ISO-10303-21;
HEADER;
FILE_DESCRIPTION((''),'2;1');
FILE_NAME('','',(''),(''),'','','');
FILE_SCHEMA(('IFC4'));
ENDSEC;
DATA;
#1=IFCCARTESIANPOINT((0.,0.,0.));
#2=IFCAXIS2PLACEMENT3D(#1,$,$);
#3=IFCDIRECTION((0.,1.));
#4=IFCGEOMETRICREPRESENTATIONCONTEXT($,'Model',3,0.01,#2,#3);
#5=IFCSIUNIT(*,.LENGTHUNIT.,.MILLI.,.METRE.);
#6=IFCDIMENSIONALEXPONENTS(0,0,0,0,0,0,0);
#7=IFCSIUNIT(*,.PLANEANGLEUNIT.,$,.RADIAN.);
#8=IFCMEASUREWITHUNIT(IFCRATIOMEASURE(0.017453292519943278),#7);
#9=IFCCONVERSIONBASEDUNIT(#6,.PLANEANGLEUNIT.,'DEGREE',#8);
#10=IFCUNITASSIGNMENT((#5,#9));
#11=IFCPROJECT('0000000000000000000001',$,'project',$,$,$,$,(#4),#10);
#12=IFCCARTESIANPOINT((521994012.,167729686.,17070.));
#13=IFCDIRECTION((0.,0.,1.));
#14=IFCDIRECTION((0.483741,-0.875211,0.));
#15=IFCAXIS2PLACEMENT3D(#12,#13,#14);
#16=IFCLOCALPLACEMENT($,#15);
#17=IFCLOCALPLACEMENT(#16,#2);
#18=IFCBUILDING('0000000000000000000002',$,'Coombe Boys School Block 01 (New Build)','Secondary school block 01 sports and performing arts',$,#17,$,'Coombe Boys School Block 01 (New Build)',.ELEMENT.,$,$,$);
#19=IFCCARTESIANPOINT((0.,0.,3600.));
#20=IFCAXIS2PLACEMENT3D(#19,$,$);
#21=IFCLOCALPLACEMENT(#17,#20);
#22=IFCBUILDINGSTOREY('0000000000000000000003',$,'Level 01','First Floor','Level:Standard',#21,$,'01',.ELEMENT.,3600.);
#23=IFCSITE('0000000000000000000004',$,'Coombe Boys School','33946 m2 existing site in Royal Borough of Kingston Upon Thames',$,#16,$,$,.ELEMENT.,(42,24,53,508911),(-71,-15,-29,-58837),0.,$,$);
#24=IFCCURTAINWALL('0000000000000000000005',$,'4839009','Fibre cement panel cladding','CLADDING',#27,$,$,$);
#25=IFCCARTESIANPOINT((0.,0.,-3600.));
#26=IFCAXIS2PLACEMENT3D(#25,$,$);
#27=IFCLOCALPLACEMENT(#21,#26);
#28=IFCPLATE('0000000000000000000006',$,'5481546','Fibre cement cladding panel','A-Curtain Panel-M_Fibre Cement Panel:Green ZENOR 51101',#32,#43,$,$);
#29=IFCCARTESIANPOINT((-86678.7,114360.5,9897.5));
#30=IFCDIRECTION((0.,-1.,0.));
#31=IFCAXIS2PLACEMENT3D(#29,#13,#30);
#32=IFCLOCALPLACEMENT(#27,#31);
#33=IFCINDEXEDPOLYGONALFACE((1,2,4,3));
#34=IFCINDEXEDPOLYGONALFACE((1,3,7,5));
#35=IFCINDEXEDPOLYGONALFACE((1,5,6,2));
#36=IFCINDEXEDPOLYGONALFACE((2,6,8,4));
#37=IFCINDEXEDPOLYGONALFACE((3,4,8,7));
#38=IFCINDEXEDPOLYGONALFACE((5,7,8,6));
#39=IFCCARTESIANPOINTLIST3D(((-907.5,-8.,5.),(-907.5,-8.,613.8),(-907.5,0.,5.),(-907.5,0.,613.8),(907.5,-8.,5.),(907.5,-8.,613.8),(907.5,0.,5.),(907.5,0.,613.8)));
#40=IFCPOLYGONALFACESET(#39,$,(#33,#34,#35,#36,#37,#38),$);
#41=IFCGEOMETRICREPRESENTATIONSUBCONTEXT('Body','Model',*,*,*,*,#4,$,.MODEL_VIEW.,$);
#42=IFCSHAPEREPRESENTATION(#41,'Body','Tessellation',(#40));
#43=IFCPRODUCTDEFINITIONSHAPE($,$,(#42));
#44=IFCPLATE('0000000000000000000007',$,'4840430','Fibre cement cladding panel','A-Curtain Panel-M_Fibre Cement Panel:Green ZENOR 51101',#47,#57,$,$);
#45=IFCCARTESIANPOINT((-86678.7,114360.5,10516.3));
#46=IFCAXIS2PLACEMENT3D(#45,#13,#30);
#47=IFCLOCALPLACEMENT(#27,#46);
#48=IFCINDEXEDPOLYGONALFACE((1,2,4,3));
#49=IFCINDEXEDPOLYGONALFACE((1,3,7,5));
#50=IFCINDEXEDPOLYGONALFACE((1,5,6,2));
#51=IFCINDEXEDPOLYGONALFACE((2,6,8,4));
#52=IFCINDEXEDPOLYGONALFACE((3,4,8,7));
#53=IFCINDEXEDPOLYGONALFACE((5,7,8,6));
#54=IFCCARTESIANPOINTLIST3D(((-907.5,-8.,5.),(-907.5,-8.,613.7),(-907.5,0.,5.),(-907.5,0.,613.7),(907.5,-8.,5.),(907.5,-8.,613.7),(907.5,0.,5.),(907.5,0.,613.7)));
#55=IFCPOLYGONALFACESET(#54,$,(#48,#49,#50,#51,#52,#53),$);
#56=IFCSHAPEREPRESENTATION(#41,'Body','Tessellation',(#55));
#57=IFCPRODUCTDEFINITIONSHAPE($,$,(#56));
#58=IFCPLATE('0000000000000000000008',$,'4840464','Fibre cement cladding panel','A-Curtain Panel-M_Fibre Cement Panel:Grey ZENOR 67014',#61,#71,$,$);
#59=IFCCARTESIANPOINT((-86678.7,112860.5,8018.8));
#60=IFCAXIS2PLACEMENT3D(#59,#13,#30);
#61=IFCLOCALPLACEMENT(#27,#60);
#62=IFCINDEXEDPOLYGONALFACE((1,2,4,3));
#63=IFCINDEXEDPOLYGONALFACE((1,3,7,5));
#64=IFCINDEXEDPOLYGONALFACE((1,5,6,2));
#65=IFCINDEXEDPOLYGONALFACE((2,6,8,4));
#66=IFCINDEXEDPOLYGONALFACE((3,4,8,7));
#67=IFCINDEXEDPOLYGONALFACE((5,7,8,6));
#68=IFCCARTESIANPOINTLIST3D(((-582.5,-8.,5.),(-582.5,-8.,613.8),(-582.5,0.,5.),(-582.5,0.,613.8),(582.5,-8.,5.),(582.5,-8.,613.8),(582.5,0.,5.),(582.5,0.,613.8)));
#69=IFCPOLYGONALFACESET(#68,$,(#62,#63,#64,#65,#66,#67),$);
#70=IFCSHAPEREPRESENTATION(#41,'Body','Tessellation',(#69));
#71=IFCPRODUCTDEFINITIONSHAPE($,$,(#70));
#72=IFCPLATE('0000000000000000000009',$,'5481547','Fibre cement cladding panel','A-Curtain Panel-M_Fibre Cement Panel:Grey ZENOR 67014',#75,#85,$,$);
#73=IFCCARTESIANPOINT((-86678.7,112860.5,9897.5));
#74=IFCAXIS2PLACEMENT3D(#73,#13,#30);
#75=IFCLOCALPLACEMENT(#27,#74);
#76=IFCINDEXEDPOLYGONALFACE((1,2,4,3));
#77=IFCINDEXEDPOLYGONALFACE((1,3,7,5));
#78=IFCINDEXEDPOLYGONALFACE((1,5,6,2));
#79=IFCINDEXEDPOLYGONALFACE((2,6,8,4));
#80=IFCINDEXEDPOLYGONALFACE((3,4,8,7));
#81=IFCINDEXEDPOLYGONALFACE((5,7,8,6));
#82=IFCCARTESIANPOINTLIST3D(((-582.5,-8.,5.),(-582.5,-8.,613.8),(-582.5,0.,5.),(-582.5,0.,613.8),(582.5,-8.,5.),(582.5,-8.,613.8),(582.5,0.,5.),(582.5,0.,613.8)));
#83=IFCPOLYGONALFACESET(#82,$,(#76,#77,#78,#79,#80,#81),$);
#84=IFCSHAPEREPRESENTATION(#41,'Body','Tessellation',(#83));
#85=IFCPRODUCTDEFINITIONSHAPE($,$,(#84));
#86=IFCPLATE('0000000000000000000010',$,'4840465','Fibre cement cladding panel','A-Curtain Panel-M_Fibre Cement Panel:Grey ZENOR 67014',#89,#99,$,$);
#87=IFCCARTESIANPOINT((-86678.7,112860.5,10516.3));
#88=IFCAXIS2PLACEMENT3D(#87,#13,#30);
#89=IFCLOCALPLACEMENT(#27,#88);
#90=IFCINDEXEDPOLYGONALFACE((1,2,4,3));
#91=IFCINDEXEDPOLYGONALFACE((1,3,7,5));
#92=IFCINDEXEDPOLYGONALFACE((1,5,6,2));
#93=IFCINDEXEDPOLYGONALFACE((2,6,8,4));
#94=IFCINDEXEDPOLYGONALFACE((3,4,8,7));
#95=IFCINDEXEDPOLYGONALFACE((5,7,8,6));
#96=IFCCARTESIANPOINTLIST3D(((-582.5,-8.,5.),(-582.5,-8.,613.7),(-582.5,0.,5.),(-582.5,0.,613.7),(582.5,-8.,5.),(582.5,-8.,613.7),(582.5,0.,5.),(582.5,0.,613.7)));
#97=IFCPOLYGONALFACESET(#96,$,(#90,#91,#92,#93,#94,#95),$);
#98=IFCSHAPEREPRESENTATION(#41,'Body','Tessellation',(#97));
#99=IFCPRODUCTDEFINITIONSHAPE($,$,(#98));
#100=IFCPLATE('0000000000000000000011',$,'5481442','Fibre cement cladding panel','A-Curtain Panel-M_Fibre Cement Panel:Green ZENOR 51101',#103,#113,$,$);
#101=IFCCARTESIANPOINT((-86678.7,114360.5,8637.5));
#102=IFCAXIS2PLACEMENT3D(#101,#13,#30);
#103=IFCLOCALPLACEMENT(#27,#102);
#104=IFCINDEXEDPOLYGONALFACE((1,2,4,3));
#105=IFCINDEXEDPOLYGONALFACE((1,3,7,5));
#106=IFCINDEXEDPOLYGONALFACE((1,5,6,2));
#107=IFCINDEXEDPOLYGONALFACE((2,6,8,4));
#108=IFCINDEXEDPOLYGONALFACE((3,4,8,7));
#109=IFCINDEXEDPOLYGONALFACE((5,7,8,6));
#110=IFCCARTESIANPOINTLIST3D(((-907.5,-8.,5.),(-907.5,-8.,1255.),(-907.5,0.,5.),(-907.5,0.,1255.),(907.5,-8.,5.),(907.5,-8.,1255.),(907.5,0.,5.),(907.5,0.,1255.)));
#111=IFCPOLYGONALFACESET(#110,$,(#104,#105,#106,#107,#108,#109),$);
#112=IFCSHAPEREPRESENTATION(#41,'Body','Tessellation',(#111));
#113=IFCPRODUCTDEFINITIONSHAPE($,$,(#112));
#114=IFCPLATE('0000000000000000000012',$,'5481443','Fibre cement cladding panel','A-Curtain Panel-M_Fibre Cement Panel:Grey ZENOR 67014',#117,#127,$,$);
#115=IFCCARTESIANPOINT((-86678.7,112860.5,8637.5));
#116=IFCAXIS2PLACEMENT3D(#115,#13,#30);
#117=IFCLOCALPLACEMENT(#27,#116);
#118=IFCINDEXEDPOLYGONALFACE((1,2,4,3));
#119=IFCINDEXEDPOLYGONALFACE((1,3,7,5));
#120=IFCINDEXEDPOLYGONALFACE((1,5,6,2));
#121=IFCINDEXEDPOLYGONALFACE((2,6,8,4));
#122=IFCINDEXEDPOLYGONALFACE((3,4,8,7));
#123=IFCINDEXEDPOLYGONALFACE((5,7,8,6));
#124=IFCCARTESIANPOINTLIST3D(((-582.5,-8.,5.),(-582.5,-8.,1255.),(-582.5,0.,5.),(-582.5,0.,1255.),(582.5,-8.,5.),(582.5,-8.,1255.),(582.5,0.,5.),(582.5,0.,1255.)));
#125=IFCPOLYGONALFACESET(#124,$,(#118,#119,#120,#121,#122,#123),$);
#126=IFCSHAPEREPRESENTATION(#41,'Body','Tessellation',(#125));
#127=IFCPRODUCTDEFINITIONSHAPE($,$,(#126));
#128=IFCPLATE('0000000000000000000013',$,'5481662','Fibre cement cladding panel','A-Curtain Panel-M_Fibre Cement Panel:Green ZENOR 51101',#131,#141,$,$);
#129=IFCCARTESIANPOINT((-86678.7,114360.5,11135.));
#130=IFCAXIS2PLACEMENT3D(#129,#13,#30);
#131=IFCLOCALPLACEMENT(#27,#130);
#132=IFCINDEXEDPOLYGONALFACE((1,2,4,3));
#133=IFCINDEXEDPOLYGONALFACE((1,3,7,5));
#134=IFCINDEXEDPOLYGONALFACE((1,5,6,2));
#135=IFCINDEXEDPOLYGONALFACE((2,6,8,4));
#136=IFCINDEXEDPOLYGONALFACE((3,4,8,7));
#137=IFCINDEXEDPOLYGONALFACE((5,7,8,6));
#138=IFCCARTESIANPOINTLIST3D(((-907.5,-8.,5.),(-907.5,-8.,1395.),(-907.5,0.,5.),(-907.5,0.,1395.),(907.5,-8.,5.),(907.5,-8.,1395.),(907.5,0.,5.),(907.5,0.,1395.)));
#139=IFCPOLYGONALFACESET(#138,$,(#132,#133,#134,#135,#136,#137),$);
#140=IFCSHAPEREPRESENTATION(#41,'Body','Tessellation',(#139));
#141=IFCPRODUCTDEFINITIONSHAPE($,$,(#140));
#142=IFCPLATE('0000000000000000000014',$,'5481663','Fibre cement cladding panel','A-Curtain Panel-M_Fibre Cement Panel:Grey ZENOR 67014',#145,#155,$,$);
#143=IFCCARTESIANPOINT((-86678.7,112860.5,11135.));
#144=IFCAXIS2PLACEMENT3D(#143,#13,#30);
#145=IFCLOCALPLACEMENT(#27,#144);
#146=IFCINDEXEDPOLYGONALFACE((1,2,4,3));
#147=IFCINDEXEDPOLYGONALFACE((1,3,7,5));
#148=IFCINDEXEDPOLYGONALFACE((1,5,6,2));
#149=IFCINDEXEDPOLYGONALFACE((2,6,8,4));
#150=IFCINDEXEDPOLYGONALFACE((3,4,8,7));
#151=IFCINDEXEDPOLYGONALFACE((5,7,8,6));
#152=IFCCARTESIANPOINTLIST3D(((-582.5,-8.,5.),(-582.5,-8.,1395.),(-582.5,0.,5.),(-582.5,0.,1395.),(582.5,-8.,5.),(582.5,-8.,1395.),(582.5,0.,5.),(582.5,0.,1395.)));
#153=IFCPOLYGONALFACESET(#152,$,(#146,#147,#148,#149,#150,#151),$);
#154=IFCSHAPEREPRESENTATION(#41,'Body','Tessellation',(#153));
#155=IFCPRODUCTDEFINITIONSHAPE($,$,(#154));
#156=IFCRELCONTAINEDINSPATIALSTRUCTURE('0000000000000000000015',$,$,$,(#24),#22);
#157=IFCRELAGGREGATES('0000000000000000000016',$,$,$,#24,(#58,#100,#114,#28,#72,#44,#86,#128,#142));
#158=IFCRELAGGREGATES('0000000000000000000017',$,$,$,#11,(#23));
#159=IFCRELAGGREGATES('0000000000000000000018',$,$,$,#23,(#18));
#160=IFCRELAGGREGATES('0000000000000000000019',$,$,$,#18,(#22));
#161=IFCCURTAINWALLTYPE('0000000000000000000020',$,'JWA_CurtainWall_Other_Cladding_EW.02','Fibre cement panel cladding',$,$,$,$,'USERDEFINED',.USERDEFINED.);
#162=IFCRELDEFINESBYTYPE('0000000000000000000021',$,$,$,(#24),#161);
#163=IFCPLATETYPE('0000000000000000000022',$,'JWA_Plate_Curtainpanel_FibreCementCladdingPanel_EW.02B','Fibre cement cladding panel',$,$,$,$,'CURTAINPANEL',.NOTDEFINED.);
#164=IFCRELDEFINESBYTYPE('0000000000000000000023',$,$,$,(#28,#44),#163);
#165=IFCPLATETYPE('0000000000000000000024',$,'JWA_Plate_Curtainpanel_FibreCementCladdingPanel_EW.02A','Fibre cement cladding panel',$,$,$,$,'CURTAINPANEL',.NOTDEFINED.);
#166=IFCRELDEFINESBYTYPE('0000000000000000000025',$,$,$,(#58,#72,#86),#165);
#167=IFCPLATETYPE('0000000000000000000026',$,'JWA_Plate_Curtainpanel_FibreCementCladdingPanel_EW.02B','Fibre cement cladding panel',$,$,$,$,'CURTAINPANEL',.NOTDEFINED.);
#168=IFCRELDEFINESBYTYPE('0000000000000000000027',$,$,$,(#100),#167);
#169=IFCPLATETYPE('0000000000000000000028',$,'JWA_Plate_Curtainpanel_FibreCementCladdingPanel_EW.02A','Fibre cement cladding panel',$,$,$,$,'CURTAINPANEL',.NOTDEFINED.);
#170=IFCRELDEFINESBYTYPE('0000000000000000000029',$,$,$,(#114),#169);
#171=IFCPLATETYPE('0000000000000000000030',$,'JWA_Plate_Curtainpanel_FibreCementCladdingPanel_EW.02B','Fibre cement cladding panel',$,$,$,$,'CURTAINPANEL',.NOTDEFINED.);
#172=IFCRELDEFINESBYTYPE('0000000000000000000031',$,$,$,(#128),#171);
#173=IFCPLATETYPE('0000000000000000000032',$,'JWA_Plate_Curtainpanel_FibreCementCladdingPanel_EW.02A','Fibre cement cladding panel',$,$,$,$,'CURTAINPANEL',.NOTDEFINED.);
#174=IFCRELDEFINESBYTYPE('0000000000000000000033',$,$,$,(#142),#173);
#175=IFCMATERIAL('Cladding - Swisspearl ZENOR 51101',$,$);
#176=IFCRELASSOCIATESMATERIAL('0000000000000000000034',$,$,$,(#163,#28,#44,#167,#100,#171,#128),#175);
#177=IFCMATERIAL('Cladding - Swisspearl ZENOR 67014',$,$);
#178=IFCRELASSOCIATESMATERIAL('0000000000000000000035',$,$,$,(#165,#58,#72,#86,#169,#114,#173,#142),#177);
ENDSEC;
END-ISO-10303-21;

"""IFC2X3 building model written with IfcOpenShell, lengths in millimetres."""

from ifc_helpers import new_model, entity, si_unit, converted_unit, direction, frame, origin, origin_2d_with_axis, place, context, subcontext, project, spatial, rectangle, extrude, source, transform, mapped, material, type_object, type_shapes, element, aggregate, save


model = new_model("IFC2X3")

# Units and contexts
model_context = context("Model", 3, precision=0.01, world=origin(), true_north=direction((0.0, 1.0)))
body_context = subcontext(model_context, "Body", "Model", "MODEL_VIEW")
ifc_project = project(units=[si_unit("LENGTHUNIT", "METRE", prefix="MILLI"), converted_unit("PLANEANGLEUNIT", "DEGREE", entity("IfcRatioMeasure", 0.017453292519943278), si_unit("PLANEANGLEUNIT", "RADIAN"), dimensions=[0, 0, 0, 0, 0, 0, 0])], contexts=[model_context])

# Site, building, storey
site_placement = place(None, frame((521994012.0, 167729686.0, 17070.0), z_axis=(0.0, 0.0, 1.0), x_axis=(0.483741, -0.875211, 0.0)))
site = spatial("IfcSite", under=ifc_project, at=site_placement, Name="Coombe Boys School", Description="33946 m2 existing site in Royal Borough of Kingston Upon Thames", CompositionType="ELEMENT", RefLatitude=(42, 24, 53, 508911), RefLongitude=(-71, -15, -29, -58837), RefElevation=0.0)
building_placement = place(site_placement, origin())
building = spatial("IfcBuilding", under=site, at=building_placement, Name="Coombe Boys School Block 01 (New Build)", Description="Secondary school block 01 sports and performing arts", LongName="Coombe Boys School Block 01 (New Build)", CompositionType="ELEMENT")
storey_placement = place(building_placement, frame((0.0, 0.0, 3600.0)))
storey = spatial("IfcBuildingStorey", under=building, at=storey_placement, Name="Level 01", Description="First Floor", ObjectType="Level:Standard", LongName="01", CompositionType="ELEMENT", Elevation=3600.0)

# Curtain wall, plates
curtain_wall_type = type_object("IfcCurtainWallType", Name="JWA_CurtainWall_Other_Cladding_EW.02", Description="Fibre cement panel cladding", ElementType="USERDEFINED", PredefinedType="USERDEFINED")
curtain_wall_placement = place(storey_placement, frame((0.0, 0.0, -3600.0)))
curtain_wall = element("IfcCurtainWall", 1, at=curtain_wall_placement, inside=storey, type_object=curtain_wall_type, Name="4839009", Description="Fibre cement panel cladding", ObjectType="CLADDING")
ifc_material_1 = material(Name="Cladding - Swisspearl ZENOR 51101")
plate_type_1 = type_object("IfcPlateType", Name="JWA_Plate_Curtainpanel_FibreCementCladdingPanel_EW.02B", Description="Fibre cement cladding panel", ElementType="CURTAINPANEL", PredefinedType="NOTDEFINED", material=ifc_material_1)
shared_shape_1 = source(origin(), body_context, "Body", "SweptSolid", [
    extrude(rectangle(XDim=1815.0, YDim=8.0, at=origin_2d_with_axis()), frame((0.0, -4.0, 5.0), z_axis=(0.0, 0.0, 1.0), x_axis=(-1.0, 0.0, 0.0)), (0.0, 0.0, 1.0), 608.8),
])
type_shapes(plate_type_1, [shared_shape_1])
plate_1_placement = place(curtain_wall_placement, frame((-86678.7, 114360.5, 9897.5), z_axis=(0.0, 0.0, 1.0), x_axis=(0.0, -1.0, 0.0)))
plate_1 = element("IfcPlate", 2, at=plate_1_placement, type_object=plate_type_1, material=ifc_material_1, Name="5481546", Description="Fibre cement cladding panel", ObjectType="A-Curtain Panel-M_Fibre Cement Panel:Green ZENOR 51101", context=body_context, shape_type="MappedRepresentation", body=[
    mapped(shared_shape_1, transform((0.0, 0.0, 0.0), scale=1.0)),
])
plate_2_placement = place(curtain_wall_placement, frame((-86678.7, 114360.5, 10516.3), z_axis=(0.0, 0.0, 1.0), x_axis=(0.0, -1.0, 0.0)))
plate_2 = element("IfcPlate", 3, at=plate_2_placement, type_object=plate_type_1, material=ifc_material_1, Name="4840430", Description="Fibre cement cladding panel", ObjectType="A-Curtain Panel-M_Fibre Cement Panel:Green ZENOR 51101", context=body_context, shape_type="MappedRepresentation", body=[
    mapped(shared_shape_1, transform((0.0, 0.0, 0.0), scale=1.0)),
])
ifc_material_2 = material(Name="Cladding - Swisspearl ZENOR 67014")
plate_type_2 = type_object("IfcPlateType", Name="JWA_Plate_Curtainpanel_FibreCementCladdingPanel_EW.02A", Description="Fibre cement cladding panel", ElementType="CURTAINPANEL", PredefinedType="NOTDEFINED", material=ifc_material_2)
shared_shape_2 = source(origin(), body_context, "Body", "SweptSolid", [
    extrude(rectangle(XDim=1165.0, YDim=8.0, at=origin_2d_with_axis()), frame((0.0, -4.0, 5.0), z_axis=(0.0, 0.0, 1.0), x_axis=(-1.0, 0.0, 0.0)), (0.0, 0.0, 1.0), 608.8),
])
type_shapes(plate_type_2, [shared_shape_2])
plate_3_placement = place(curtain_wall_placement, frame((-86678.7, 112860.5, 8018.8), z_axis=(0.0, 0.0, 1.0), x_axis=(0.0, -1.0, 0.0)))
plate_3 = element("IfcPlate", 4, at=plate_3_placement, type_object=plate_type_2, material=ifc_material_2, Name="4840464", Description="Fibre cement cladding panel", ObjectType="A-Curtain Panel-M_Fibre Cement Panel:Grey ZENOR 67014", context=body_context, shape_type="MappedRepresentation", body=[
    mapped(shared_shape_2, transform((0.0, 0.0, 0.0), scale=1.0)),
])
plate_4_placement = place(curtain_wall_placement, frame((-86678.7, 112860.5, 9897.5), z_axis=(0.0, 0.0, 1.0), x_axis=(0.0, -1.0, 0.0)))
plate_4 = element("IfcPlate", 5, at=plate_4_placement, type_object=plate_type_2, material=ifc_material_2, Name="5481547", Description="Fibre cement cladding panel", ObjectType="A-Curtain Panel-M_Fibre Cement Panel:Grey ZENOR 67014", context=body_context, shape_type="MappedRepresentation", body=[
    mapped(shared_shape_2, transform((0.0, 0.0, 0.0), scale=1.0)),
])
plate_5_placement = place(curtain_wall_placement, frame((-86678.7, 112860.5, 10516.3), z_axis=(0.0, 0.0, 1.0), x_axis=(0.0, -1.0, 0.0)))
plate_5 = element("IfcPlate", 6, at=plate_5_placement, type_object=plate_type_2, material=ifc_material_2, Name="4840465", Description="Fibre cement cladding panel", ObjectType="A-Curtain Panel-M_Fibre Cement Panel:Grey ZENOR 67014", context=body_context, shape_type="MappedRepresentation", body=[
    mapped(shared_shape_2, transform((0.0, 0.0, 0.0), scale=1.0)),
])
plate_type_3 = type_object("IfcPlateType", Name="JWA_Plate_Curtainpanel_FibreCementCladdingPanel_EW.02B", Description="Fibre cement cladding panel", ElementType="CURTAINPANEL", PredefinedType="NOTDEFINED", material=ifc_material_1)
shared_shape_3 = source(origin(), body_context, "Body", "SweptSolid", [
    extrude(rectangle(XDim=1815.0, YDim=8.0, at=origin_2d_with_axis()), frame((0.0, -4.0, 5.0), z_axis=(0.0, 0.0, 1.0), x_axis=(-1.0, 0.0, 0.0)), (0.0, 0.0, 1.0), 1250.0),
])
type_shapes(plate_type_3, [shared_shape_3])
plate_6_placement = place(curtain_wall_placement, frame((-86678.7, 114360.5, 8637.5), z_axis=(0.0, 0.0, 1.0), x_axis=(0.0, -1.0, 0.0)))
plate_6 = element("IfcPlate", 7, at=plate_6_placement, type_object=plate_type_3, material=ifc_material_1, Name="5481442", Description="Fibre cement cladding panel", ObjectType="A-Curtain Panel-M_Fibre Cement Panel:Green ZENOR 51101", context=body_context, shape_type="MappedRepresentation", body=[
    mapped(shared_shape_3, transform((0.0, 0.0, 0.0), scale=1.0)),
])
plate_type_4 = type_object("IfcPlateType", Name="JWA_Plate_Curtainpanel_FibreCementCladdingPanel_EW.02A", Description="Fibre cement cladding panel", ElementType="CURTAINPANEL", PredefinedType="NOTDEFINED", material=ifc_material_2)
shared_shape_4 = source(origin(), body_context, "Body", "SweptSolid", [
    extrude(rectangle(XDim=1165.0, YDim=8.0, at=origin_2d_with_axis()), frame((0.0, -4.0, 5.0), z_axis=(0.0, 0.0, 1.0), x_axis=(-1.0, 0.0, 0.0)), (0.0, 0.0, 1.0), 1250.0),
])
type_shapes(plate_type_4, [shared_shape_4])
plate_7_placement = place(curtain_wall_placement, frame((-86678.7, 112860.5, 8637.5), z_axis=(0.0, 0.0, 1.0), x_axis=(0.0, -1.0, 0.0)))
plate_7 = element("IfcPlate", 8, at=plate_7_placement, type_object=plate_type_4, material=ifc_material_2, Name="5481443", Description="Fibre cement cladding panel", ObjectType="A-Curtain Panel-M_Fibre Cement Panel:Grey ZENOR 67014", context=body_context, shape_type="MappedRepresentation", body=[
    mapped(shared_shape_4, transform((0.0, 0.0, 0.0), scale=1.0)),
])
plate_type_5 = type_object("IfcPlateType", Name="JWA_Plate_Curtainpanel_FibreCementCladdingPanel_EW.02B", Description="Fibre cement cladding panel", ElementType="CURTAINPANEL", PredefinedType="NOTDEFINED", material=ifc_material_1)
shared_shape_5 = source(origin(), body_context, "Body", "SweptSolid", [
    extrude(rectangle(XDim=1815.0, YDim=8.0, at=origin_2d_with_axis()), frame((0.0, -4.0, 5.0), z_axis=(0.0, 0.0, 1.0), x_axis=(-1.0, 0.0, 0.0)), (0.0, 0.0, 1.0), 1390.0),
])
type_shapes(plate_type_5, [shared_shape_5])
plate_8_placement = place(curtain_wall_placement, frame((-86678.7, 114360.5, 11135.0), z_axis=(0.0, 0.0, 1.0), x_axis=(0.0, -1.0, 0.0)))
plate_8 = element("IfcPlate", 9, at=plate_8_placement, type_object=plate_type_5, material=ifc_material_1, Name="5481662", Description="Fibre cement cladding panel", ObjectType="A-Curtain Panel-M_Fibre Cement Panel:Green ZENOR 51101", context=body_context, shape_type="MappedRepresentation", body=[
    mapped(shared_shape_5, transform((0.0, 0.0, 0.0), scale=1.0)),
])
plate_type_6 = type_object("IfcPlateType", Name="JWA_Plate_Curtainpanel_FibreCementCladdingPanel_EW.02A", Description="Fibre cement cladding panel", ElementType="CURTAINPANEL", PredefinedType="NOTDEFINED", material=ifc_material_2)
shared_shape_6 = source(origin(), body_context, "Body", "SweptSolid", [
    extrude(rectangle(XDim=1165.0, YDim=8.0, at=origin_2d_with_axis()), frame((0.0, -4.0, 5.0), z_axis=(0.0, 0.0, 1.0), x_axis=(-1.0, 0.0, 0.0)), (0.0, 0.0, 1.0), 1390.0),
])
type_shapes(plate_type_6, [shared_shape_6])
plate_9_placement = place(curtain_wall_placement, frame((-86678.7, 112860.5, 11135.0), z_axis=(0.0, 0.0, 1.0), x_axis=(0.0, -1.0, 0.0)))
plate_9 = element("IfcPlate", 10, at=plate_9_placement, type_object=plate_type_6, material=ifc_material_2, Name="5481663", Description="Fibre cement cladding panel", ObjectType="A-Curtain Panel-M_Fibre Cement Panel:Grey ZENOR 67014", context=body_context, shape_type="MappedRepresentation", body=[
    mapped(shared_shape_6, transform((0.0, 0.0, 0.0), scale=1.0)),
])
aggregate(curtain_wall, [plate_3, plate_6, plate_7, plate_1, plate_4, plate_2, plate_5, plate_8, plate_9])

save(model, "model.ifc")
